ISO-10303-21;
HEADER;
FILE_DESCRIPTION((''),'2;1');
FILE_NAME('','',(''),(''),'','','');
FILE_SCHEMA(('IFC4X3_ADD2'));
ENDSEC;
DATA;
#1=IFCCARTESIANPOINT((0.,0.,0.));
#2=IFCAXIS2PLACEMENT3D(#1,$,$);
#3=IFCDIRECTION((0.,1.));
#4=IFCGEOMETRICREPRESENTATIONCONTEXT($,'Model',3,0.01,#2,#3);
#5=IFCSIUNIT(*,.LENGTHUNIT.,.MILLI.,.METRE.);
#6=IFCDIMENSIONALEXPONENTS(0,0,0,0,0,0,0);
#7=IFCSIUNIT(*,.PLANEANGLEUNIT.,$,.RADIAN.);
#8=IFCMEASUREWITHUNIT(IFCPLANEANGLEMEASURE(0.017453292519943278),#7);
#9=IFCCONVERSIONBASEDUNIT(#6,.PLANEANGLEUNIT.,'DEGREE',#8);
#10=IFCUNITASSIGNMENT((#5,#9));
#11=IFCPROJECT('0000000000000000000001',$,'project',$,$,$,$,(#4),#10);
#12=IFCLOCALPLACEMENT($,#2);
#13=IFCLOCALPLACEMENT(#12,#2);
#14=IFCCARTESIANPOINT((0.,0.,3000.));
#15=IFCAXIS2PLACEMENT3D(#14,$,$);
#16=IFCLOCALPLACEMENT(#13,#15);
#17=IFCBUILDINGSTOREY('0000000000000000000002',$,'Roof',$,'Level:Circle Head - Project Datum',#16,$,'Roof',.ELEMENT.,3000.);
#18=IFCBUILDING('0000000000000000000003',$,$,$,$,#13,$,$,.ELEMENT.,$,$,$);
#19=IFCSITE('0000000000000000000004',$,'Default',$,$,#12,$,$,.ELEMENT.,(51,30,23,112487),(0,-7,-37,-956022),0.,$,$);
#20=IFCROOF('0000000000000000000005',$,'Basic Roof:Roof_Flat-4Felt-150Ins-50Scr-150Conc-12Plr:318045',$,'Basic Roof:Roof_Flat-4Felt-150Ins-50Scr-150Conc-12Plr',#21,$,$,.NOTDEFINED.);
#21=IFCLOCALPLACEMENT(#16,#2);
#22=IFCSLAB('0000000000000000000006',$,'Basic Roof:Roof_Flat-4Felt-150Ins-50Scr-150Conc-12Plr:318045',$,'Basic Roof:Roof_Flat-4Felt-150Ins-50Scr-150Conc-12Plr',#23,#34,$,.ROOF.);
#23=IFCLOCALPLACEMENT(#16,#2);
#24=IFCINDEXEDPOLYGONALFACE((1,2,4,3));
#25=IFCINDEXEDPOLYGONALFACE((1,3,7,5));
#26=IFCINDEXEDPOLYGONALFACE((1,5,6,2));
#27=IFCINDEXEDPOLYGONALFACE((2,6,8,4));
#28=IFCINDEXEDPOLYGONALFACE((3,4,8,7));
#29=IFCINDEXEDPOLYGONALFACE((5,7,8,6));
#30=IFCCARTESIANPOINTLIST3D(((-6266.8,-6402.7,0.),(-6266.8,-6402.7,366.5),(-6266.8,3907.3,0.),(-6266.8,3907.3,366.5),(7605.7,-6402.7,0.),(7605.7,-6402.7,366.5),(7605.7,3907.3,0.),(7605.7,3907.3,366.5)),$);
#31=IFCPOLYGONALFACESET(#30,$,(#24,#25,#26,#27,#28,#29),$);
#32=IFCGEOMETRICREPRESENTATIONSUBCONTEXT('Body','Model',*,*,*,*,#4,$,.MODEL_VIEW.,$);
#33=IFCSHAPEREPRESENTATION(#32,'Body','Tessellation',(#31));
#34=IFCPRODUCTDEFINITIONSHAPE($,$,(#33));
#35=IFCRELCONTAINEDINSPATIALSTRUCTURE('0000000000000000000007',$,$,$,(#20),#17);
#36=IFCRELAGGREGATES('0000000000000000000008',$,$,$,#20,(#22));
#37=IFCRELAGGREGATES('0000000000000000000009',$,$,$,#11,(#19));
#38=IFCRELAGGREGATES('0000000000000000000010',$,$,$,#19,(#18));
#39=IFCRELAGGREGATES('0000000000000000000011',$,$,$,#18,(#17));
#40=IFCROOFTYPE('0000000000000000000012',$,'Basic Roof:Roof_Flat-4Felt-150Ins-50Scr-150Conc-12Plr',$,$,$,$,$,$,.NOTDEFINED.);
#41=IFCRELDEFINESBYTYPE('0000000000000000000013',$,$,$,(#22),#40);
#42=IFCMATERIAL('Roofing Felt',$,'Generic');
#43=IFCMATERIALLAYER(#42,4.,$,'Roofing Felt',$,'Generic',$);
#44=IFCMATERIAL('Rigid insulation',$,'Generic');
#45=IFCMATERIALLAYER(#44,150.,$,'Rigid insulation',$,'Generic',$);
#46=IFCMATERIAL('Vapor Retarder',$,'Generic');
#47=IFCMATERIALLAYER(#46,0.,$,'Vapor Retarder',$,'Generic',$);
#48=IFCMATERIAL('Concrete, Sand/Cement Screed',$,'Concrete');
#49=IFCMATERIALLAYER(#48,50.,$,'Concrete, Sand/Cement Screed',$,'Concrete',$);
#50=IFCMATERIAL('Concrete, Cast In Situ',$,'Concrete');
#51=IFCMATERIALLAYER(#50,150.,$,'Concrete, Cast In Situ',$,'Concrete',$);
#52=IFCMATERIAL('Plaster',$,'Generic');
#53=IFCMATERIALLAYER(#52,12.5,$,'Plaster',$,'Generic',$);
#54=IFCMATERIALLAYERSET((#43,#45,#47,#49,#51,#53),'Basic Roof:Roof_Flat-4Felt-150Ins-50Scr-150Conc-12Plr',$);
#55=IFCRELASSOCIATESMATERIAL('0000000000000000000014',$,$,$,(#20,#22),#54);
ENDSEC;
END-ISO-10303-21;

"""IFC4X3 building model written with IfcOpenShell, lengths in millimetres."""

from ifc_helpers import new_model, entity, si_unit, converted_unit, direction, frame, frame_2d, origin, place, context, subcontext, project, spatial, rectangle, extrude, material, layer, layer_set, type_object, element, aggregate, save


model = new_model("IFC4X3")

# Units and contexts
model_context = context("Model", 3, precision=0.01, world=origin(), true_north=direction((0.0, 1.0)))
body_context = subcontext(model_context, "Body", "Model", "MODEL_VIEW")
ifc_project = project(units=[si_unit("LENGTHUNIT", "METRE", prefix="MILLI"), converted_unit("PLANEANGLEUNIT", "DEGREE", entity("IfcPlaneAngleMeasure", 0.017453292519943278), si_unit("PLANEANGLEUNIT", "RADIAN"), dimensions=[0, 0, 0, 0, 0, 0, 0])], contexts=[model_context])

# Site, building, storey
site_placement = place(None, origin())
site = spatial("IfcSite", under=ifc_project, at=site_placement, Name="Default", CompositionType="ELEMENT", RefLatitude=(51, 30, 23, 112487), RefLongitude=(0, -7, -37, -956022), RefElevation=0.0)
building_placement = place(site_placement, origin())
building = spatial("IfcBuilding", under=site, at=building_placement, CompositionType="ELEMENT")
storey_placement = place(building_placement, frame((0.0, 0.0, 3000.0)))
storey = spatial("IfcBuildingStorey", under=building, at=storey_placement, Name="Roof", ObjectType="Level:Circle Head - Project Datum", LongName="Roof", CompositionType="ELEMENT", Elevation=3000.0)

# Roof, slab
ifc_material_1 = material(Name="Roofing Felt", Category="Generic")
ifc_layer_1 = layer(ifc_material_1, 4.0, Name="Roofing Felt", Category="Generic")
ifc_material_2 = material(Name="Rigid insulation", Category="Generic")
ifc_layer_2 = layer(ifc_material_2, 150.0, Name="Rigid insulation", Category="Generic")
ifc_material_3 = material(Name="Vapor Retarder", Category="Generic")
ifc_layer_3 = layer(ifc_material_3, 0.0, Name="Vapor Retarder", Category="Generic")
ifc_material_4 = material(Name="Concrete, Sand/Cement Screed", Category="Concrete")
ifc_layer_4 = layer(ifc_material_4, 50.0, Name="Concrete, Sand/Cement Screed", Category="Concrete")
ifc_material_5 = material(Name="Concrete, Cast In Situ", Category="Concrete")
ifc_layer_5 = layer(ifc_material_5, 150.0, Name="Concrete, Cast In Situ", Category="Concrete")
ifc_material_6 = material(Name="Plaster", Category="Generic")
ifc_layer_6 = layer(ifc_material_6, 12.5, Name="Plaster", Category="Generic")
ifc_layer_set = layer_set([ifc_layer_1, ifc_layer_2, ifc_layer_3, ifc_layer_4, ifc_layer_5, ifc_layer_6], Name="Basic Roof:Roof_Flat-4Felt-150Ins-50Scr-150Conc-12Plr")
roof_placement = place(storey_placement, frame((-6266.8, -6402.7, 0.0)))
roof = element("IfcRoof", 1, at=roof_placement, inside=storey, material=ifc_layer_set, Name="Basic Roof:Roof_Flat-4Felt-150Ins-50Scr-150Conc-12Plr:318045", ObjectType="Basic Roof:Roof_Flat-4Felt-150Ins-50Scr-150Conc-12Plr", PredefinedType="NOTDEFINED")
roof_type = type_object("IfcRoofType", Name="Basic Roof:Roof_Flat-4Felt-150Ins-50Scr-150Conc-12Plr", PredefinedType="NOTDEFINED")
slab_placement = place(roof_placement, origin())
slab = element("IfcSlab", 2, at=slab_placement, type_object=roof_type, material=ifc_layer_set, Name="Basic Roof:Roof_Flat-4Felt-150Ins-50Scr-150Conc-12Plr:318045", ObjectType="Basic Roof:Roof_Flat-4Felt-150Ins-50Scr-150Conc-12Plr", PredefinedType="ROOF", context=body_context, shape_type="SweptSolid", body=[
    extrude(rectangle(XDim=13872.5, YDim=10310.0, at=frame_2d((0.0, 0.0), x_axis=(1.0, 0.0))), frame((6936.3, 5155.0, 0.0)), (0.0, 0.0, 1.0), 366.5),
])
aggregate(roof, [slab])

save(model, "model.ifc")
